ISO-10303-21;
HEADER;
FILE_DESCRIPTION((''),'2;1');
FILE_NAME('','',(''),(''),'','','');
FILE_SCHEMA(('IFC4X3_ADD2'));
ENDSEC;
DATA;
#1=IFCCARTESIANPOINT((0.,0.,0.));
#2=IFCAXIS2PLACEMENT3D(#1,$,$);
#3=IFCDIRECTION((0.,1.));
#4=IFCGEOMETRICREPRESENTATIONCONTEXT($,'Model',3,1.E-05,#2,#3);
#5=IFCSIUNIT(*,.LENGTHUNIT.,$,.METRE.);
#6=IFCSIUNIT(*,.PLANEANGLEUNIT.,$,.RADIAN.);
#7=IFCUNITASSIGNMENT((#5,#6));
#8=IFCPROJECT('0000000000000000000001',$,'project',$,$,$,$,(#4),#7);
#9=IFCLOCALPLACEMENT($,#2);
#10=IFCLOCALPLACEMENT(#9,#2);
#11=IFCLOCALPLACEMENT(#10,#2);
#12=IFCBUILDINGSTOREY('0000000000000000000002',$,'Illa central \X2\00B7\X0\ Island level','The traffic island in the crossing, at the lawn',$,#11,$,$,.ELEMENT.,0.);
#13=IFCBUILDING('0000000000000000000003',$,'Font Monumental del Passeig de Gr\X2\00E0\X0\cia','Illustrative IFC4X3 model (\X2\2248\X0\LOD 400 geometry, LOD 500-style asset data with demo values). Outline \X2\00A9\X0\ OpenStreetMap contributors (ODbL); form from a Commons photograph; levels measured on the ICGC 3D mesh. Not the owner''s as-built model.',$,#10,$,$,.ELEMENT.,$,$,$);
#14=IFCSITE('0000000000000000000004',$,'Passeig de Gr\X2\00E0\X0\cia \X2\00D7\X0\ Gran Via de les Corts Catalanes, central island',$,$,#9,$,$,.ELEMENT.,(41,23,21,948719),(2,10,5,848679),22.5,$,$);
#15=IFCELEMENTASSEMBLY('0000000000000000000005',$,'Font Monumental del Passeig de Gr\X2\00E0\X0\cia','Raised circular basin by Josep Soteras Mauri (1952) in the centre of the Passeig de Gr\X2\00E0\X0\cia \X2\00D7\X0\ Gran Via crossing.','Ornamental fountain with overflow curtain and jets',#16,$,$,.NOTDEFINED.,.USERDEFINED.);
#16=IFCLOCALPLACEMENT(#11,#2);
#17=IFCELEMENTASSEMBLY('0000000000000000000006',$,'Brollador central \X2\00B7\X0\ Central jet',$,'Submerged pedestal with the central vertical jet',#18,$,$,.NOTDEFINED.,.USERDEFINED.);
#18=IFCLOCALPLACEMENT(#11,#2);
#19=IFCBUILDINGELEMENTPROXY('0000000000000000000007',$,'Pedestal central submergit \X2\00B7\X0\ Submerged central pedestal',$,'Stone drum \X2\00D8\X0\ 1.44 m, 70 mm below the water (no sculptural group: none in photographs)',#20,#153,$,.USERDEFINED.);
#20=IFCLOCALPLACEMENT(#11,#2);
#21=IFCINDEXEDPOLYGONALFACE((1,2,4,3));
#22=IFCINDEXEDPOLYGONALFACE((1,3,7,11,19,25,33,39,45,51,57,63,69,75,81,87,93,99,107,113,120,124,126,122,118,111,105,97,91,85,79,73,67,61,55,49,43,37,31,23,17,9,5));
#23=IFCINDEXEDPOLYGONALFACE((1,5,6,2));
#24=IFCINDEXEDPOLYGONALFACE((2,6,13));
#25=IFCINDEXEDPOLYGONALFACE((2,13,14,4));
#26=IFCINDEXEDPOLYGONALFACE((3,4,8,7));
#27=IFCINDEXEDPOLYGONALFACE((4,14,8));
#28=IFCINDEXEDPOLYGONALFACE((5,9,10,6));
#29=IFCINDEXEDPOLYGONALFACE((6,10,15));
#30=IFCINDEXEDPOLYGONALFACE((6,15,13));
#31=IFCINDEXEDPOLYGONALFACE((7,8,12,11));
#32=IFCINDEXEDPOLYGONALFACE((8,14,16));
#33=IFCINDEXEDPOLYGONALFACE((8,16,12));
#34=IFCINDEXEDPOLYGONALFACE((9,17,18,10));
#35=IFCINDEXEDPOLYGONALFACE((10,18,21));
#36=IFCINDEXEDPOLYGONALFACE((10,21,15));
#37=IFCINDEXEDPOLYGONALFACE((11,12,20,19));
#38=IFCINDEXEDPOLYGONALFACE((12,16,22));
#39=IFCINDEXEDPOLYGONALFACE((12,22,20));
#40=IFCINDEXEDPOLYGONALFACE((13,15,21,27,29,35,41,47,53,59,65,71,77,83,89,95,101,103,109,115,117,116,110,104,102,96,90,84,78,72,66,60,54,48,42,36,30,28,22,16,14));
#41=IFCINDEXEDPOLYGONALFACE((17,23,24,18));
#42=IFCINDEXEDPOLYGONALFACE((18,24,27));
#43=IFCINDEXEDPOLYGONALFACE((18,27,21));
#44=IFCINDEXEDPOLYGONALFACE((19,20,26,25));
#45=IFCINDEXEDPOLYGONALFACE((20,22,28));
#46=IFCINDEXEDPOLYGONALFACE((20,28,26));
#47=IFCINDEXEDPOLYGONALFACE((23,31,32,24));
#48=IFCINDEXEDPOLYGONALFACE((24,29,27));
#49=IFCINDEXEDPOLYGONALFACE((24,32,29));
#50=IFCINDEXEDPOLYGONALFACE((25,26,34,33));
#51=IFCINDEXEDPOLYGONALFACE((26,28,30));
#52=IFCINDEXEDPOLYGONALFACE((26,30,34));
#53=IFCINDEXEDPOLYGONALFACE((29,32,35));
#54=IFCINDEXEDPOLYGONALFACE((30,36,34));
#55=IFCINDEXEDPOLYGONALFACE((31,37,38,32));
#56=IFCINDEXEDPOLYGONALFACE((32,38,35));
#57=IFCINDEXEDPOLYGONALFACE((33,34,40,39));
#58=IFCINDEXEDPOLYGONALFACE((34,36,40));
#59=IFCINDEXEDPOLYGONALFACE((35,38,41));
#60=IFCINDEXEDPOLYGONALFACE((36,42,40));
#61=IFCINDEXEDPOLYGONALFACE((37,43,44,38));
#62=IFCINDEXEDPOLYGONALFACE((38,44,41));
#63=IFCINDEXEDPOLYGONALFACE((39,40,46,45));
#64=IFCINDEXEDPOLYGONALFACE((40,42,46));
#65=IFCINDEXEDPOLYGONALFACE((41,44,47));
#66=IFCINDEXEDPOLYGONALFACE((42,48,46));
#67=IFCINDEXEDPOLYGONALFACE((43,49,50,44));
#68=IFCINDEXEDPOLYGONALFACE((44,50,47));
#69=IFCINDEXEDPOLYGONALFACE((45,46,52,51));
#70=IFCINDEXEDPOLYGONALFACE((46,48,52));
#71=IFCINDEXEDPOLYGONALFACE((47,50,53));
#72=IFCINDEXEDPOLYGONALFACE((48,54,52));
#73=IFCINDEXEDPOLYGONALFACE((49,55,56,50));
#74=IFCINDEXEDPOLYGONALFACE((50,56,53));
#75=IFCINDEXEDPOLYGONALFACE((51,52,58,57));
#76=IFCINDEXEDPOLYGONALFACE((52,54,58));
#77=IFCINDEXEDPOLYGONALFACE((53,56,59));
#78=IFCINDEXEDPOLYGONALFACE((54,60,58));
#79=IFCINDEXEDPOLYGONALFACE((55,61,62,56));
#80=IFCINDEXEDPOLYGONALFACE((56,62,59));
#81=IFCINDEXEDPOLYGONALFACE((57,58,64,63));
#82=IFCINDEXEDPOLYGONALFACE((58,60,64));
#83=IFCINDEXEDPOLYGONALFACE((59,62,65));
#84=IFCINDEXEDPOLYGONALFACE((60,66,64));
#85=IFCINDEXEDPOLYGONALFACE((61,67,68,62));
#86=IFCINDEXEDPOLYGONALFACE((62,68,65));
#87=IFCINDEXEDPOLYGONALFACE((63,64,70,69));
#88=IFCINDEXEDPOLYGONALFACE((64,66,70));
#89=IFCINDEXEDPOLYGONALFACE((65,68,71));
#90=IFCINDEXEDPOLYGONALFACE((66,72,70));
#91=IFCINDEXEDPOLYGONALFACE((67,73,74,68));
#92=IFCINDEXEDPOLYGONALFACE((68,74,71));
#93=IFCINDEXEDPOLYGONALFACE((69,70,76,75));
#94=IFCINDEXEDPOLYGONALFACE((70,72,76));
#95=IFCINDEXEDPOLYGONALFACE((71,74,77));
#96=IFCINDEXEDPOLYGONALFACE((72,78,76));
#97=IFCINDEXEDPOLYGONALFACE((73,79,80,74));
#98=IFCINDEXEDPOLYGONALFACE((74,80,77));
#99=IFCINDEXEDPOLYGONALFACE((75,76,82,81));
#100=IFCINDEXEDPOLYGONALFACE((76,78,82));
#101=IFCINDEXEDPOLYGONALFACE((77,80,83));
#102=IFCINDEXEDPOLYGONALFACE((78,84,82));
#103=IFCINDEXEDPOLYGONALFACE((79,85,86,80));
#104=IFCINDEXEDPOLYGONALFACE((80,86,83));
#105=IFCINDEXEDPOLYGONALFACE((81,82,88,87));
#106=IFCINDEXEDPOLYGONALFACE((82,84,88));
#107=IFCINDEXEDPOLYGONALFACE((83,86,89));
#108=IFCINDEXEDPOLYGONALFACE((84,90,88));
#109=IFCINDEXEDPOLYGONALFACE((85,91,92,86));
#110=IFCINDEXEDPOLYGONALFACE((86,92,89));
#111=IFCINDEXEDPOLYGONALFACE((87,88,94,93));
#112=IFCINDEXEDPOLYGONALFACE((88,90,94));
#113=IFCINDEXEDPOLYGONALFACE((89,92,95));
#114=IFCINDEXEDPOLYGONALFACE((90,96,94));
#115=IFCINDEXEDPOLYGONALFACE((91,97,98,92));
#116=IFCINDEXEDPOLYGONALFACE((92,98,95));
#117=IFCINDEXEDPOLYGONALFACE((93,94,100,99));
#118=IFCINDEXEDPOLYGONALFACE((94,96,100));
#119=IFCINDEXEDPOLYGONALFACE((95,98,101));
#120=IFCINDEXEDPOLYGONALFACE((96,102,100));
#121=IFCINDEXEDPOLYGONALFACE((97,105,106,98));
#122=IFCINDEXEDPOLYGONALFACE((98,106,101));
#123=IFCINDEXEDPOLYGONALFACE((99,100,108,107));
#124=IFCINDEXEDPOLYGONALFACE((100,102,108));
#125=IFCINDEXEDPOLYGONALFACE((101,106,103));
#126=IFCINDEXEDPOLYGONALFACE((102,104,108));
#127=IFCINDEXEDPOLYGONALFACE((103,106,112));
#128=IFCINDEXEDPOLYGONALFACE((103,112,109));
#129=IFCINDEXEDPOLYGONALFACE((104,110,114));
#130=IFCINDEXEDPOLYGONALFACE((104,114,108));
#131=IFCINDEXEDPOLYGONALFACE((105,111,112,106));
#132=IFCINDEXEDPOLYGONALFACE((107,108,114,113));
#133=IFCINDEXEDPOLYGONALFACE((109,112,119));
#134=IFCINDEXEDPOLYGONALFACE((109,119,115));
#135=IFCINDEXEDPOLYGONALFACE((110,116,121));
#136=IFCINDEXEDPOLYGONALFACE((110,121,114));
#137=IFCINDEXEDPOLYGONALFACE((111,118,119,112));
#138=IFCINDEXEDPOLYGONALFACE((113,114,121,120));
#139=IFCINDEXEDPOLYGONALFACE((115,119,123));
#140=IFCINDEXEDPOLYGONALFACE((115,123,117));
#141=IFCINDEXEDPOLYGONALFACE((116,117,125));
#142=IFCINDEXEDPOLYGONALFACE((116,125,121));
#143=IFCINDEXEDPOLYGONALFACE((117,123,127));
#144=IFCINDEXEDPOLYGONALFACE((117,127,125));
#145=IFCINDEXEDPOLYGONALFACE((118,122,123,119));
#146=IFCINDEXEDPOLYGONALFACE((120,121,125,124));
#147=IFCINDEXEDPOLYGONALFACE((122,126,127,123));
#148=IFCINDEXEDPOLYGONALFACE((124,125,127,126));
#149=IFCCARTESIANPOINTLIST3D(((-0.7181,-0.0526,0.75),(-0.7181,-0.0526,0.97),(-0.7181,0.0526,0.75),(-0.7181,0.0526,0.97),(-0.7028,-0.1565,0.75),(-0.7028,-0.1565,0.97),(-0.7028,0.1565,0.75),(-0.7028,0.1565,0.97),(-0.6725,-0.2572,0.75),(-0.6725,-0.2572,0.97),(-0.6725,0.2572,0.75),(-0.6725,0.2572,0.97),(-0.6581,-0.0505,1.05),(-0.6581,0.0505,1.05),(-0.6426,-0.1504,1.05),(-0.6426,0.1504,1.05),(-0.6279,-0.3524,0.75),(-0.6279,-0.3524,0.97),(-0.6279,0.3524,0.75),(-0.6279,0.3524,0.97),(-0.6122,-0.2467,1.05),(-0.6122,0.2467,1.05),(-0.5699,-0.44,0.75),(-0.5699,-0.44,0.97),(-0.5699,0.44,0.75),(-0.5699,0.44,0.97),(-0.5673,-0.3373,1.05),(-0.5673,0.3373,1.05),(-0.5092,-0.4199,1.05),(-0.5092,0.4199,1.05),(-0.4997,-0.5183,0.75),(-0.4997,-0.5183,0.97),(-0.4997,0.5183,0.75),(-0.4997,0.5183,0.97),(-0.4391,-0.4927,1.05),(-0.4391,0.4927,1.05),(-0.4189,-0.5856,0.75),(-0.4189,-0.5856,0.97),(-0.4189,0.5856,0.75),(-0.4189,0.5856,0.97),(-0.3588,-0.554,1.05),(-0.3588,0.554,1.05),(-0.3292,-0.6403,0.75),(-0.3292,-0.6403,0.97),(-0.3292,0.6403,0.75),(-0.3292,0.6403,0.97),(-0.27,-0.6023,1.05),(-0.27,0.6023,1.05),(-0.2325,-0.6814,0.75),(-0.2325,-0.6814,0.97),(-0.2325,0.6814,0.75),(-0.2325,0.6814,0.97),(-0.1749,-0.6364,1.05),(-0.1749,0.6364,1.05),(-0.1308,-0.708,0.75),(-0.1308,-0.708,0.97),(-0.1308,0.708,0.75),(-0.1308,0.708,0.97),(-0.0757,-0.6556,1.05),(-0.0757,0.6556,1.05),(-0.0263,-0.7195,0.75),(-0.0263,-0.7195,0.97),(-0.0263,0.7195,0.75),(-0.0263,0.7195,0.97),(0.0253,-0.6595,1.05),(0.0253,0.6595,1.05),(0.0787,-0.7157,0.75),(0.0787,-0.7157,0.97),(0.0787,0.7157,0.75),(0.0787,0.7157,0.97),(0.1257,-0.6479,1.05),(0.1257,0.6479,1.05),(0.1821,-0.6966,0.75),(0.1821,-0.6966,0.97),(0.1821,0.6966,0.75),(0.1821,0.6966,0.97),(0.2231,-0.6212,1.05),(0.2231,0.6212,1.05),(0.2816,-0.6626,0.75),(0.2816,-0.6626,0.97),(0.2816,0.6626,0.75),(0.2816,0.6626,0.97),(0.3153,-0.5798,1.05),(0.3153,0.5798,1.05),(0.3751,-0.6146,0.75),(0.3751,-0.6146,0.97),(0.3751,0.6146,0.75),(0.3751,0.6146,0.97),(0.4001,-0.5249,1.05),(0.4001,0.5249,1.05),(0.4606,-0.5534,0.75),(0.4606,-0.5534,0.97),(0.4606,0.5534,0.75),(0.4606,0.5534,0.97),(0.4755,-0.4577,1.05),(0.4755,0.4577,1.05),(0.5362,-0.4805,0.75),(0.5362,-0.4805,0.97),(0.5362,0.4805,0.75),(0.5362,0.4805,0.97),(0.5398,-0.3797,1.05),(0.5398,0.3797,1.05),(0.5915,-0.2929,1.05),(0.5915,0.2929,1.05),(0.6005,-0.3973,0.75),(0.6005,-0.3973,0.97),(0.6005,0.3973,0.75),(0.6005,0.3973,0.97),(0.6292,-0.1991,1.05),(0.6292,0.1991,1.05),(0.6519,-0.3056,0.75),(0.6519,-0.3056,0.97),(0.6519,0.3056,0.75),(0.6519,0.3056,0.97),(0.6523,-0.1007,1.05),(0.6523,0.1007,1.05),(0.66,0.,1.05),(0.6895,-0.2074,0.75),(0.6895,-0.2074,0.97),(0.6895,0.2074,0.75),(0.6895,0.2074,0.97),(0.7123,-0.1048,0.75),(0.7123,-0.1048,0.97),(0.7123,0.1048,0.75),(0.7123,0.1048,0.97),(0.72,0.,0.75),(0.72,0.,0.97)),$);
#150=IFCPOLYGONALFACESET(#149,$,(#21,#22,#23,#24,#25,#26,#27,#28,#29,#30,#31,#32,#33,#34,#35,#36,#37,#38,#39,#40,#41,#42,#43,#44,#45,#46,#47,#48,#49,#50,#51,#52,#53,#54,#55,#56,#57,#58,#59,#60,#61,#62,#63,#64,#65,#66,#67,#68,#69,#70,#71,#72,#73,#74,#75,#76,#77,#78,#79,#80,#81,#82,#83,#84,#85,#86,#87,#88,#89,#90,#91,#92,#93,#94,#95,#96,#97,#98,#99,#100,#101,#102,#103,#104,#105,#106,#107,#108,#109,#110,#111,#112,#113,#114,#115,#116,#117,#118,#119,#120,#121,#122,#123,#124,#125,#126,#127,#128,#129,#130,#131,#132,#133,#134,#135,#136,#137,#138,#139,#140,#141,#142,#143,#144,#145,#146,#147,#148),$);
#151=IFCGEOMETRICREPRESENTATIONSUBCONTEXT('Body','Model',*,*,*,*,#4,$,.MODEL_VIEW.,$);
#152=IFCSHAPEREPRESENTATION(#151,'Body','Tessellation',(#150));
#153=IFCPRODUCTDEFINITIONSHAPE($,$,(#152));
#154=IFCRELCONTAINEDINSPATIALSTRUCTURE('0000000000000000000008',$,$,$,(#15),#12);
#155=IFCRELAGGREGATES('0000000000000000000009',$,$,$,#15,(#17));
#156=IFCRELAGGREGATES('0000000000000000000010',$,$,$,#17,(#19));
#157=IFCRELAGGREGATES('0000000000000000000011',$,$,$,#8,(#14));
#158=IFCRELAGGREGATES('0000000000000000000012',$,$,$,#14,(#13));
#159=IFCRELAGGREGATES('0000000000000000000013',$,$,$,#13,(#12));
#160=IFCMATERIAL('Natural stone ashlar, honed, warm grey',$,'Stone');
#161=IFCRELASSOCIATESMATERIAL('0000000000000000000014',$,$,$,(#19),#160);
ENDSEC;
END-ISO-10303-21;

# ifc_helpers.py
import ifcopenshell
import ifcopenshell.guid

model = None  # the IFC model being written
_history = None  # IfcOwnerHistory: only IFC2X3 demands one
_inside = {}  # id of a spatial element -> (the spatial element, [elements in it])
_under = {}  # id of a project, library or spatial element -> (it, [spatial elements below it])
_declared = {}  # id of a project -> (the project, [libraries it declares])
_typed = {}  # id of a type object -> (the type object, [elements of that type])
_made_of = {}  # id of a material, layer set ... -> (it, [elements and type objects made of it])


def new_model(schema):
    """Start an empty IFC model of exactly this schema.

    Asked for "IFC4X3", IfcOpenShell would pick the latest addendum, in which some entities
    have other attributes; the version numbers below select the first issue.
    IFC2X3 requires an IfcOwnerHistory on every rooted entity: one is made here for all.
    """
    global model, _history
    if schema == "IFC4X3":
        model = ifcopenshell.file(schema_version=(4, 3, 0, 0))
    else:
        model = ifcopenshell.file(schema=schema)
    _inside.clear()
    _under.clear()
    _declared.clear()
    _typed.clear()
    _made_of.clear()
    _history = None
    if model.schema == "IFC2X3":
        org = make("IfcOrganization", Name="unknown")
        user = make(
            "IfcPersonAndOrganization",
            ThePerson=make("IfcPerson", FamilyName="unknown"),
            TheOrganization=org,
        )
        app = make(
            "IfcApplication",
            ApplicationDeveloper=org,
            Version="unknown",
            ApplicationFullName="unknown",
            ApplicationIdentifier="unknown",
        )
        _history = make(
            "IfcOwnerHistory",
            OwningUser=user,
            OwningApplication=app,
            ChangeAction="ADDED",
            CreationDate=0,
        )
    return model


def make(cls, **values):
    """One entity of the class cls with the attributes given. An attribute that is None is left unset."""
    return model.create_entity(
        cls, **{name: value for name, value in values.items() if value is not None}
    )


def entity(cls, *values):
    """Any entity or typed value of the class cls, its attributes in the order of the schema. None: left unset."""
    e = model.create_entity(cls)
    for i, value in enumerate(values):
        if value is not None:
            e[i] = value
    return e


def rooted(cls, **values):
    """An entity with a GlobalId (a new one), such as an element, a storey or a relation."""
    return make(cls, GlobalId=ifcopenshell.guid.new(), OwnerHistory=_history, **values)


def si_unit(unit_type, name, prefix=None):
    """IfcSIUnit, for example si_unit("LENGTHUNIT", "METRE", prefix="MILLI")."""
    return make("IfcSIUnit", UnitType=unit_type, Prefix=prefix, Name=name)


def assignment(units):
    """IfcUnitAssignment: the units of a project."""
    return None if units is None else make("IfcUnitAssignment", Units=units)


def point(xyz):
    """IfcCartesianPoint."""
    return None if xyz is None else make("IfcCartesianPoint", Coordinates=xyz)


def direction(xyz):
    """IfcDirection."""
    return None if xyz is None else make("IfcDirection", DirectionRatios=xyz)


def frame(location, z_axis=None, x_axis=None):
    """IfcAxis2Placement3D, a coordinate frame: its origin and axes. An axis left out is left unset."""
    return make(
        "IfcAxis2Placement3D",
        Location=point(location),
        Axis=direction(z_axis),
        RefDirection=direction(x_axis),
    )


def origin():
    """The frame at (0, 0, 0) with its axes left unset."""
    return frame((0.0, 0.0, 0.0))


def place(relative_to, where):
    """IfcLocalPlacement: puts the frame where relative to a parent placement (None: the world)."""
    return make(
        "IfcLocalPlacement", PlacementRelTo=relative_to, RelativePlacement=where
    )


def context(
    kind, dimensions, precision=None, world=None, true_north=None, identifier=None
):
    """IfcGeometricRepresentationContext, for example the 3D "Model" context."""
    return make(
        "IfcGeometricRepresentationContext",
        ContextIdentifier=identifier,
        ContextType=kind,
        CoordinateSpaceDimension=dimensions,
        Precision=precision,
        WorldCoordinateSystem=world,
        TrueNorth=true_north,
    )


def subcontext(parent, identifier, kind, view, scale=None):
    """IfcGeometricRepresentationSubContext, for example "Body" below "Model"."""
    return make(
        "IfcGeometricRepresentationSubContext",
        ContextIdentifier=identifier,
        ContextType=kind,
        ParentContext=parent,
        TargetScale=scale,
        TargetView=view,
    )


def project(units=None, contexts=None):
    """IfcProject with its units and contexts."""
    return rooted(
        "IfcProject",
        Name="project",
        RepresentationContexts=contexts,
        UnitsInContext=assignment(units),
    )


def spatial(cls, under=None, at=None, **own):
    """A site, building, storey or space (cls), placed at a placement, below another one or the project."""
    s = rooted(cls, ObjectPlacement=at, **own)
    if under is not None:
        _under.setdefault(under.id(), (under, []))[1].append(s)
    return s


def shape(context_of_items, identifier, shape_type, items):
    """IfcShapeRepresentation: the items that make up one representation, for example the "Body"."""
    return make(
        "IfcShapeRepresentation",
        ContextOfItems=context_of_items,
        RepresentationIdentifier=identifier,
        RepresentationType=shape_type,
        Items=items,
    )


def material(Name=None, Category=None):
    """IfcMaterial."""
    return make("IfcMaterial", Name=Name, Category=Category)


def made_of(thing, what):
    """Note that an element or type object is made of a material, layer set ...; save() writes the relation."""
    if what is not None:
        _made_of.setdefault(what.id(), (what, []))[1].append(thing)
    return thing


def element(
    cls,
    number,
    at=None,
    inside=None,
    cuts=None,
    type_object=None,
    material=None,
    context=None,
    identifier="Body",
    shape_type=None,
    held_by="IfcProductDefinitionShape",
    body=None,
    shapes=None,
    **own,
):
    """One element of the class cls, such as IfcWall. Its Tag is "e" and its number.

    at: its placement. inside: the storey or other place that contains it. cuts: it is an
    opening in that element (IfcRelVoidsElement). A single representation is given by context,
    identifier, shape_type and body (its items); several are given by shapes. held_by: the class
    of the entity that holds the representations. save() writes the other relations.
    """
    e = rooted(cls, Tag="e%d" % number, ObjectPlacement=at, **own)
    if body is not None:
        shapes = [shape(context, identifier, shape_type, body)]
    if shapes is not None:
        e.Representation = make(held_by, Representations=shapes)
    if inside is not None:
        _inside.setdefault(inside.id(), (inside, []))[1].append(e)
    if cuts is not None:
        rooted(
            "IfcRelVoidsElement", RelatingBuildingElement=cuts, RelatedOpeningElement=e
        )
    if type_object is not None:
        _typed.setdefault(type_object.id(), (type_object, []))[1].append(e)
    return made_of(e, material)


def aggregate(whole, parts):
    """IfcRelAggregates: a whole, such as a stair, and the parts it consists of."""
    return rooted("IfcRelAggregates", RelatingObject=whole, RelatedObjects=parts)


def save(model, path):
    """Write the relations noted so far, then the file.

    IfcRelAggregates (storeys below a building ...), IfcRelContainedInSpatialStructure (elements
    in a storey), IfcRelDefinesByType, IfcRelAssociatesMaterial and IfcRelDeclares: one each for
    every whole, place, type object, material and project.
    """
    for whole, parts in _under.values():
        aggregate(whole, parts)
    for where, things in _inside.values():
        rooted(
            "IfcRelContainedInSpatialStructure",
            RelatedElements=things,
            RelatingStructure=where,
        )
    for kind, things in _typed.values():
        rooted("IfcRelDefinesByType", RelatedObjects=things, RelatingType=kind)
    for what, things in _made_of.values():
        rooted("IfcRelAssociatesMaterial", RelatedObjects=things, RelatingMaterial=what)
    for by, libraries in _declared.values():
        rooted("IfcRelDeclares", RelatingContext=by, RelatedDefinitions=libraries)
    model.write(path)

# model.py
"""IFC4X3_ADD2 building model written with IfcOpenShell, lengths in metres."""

from ifc_helpers import new_model, entity, si_unit, direction, origin, place, context, subcontext, project, spatial, material, element, aggregate, save


model = new_model("IFC4X3_ADD2")

# Units and contexts
model_context = context("Model", 3, precision=1e-05, world=origin(), true_north=direction((0.0, 1.0)))
body_context = subcontext(model_context, "Body", "Model", "MODEL_VIEW")
ifc_project = project(units=[si_unit("LENGTHUNIT", "METRE"), si_unit("PLANEANGLEUNIT", "RADIAN")], contexts=[model_context])

# Site, building, storey
site_placement = place(None, origin())
site = spatial("IfcSite", under=ifc_project, at=site_placement, Name="Passeig de Gràcia × Gran Via de les Corts Catalanes, central island", CompositionType="ELEMENT", RefLatitude=(41, 23, 21, 948719), RefLongitude=(2, 10, 5, 848679), RefElevation=22.5)
building_placement = place(site_placement, origin())
building = spatial("IfcBuilding", under=site, at=building_placement, Name="Font Monumental del Passeig de Gràcia", Description="Illustrative IFC4X3 model (≈LOD 400 geometry, LOD 500-style asset data with demo values). Outline © OpenStreetMap contributors (ODbL); form from a Commons photograph; levels measured on the ICGC 3D mesh. Not the owner's as-built model.", CompositionType="ELEMENT")
storey_placement = place(building_placement, origin())
storey = spatial("IfcBuildingStorey", under=building, at=storey_placement, Name="Illa central · Island level", Description="The traffic island in the crossing, at the lawn", CompositionType="ELEMENT", Elevation=0.0)

# Element assemblies, building element proxy
assembly_1_placement = place(building_placement, origin())
assembly_1 = element("IfcElementAssembly", 1, at=assembly_1_placement, inside=storey, Name="Font Monumental del Passeig de Gràcia", Description="Raised circular basin by Josep Soteras Mauri (1952) in the centre of the Passeig de Gràcia × Gran Via crossing.", ObjectType="Ornamental fountain with overflow curtain and jets", AssemblyPlace="NOTDEFINED", PredefinedType="USERDEFINED")
ifc_material_1 = material(Name="Natural stone ashlar, honed, warm grey", Category="Stone")
assembly_2_placement = place(building_placement, origin())
assembly_2 = element("IfcElementAssembly", 2, at=assembly_2_placement, Name="Brollador central · Central jet", ObjectType="Submerged pedestal with the central vertical jet", AssemblyPlace="NOTDEFINED", PredefinedType="USERDEFINED")
aggregate(assembly_1, [assembly_2])
proxy_1_placement = place(building_placement, origin())
proxy_1 = element("IfcBuildingElementProxy", 3, at=proxy_1_placement, material=ifc_material_1, Name="Pedestal central submergit · Submerged central pedestal", ObjectType="Stone drum Ø 1.44 m, 70 mm below the water (no sculptural group: none in photographs)", PredefinedType="USERDEFINED", context=body_context, shape_type="SweptSolid", body=[
    entity("IfcRevolvedAreaSolid", entity("IfcArbitraryClosedProfileDef", "AREA", None, entity("IfcPolyline", [entity("IfcCartesianPoint", [0.0, 0.0]), entity("IfcCartesianPoint", [0.72, 0.0]), entity("IfcCartesianPoint", [0.72, 0.22]), entity("IfcCartesianPoint", [0.66, 0.3]), entity("IfcCartesianPoint", [0.0, 0.3]), entity("IfcCartesianPoint", [0.0, 0.0])])), entity("IfcAxis2Placement3D", entity("IfcCartesianPoint", [0.0, 0.0, 0.75]), entity("IfcDirection", [0.0, -1.0, 0.0]), entity("IfcDirection", [1.0, 0.0, 0.0])), entity("IfcAxis1Placement", entity("IfcCartesianPoint", [0.0, 0.0, 0.0]), entity("IfcDirection", [0.0, 1.0, 0.0])), 6.283185),
])
aggregate(assembly_2, [proxy_1])

save(model, "model.ifc")
